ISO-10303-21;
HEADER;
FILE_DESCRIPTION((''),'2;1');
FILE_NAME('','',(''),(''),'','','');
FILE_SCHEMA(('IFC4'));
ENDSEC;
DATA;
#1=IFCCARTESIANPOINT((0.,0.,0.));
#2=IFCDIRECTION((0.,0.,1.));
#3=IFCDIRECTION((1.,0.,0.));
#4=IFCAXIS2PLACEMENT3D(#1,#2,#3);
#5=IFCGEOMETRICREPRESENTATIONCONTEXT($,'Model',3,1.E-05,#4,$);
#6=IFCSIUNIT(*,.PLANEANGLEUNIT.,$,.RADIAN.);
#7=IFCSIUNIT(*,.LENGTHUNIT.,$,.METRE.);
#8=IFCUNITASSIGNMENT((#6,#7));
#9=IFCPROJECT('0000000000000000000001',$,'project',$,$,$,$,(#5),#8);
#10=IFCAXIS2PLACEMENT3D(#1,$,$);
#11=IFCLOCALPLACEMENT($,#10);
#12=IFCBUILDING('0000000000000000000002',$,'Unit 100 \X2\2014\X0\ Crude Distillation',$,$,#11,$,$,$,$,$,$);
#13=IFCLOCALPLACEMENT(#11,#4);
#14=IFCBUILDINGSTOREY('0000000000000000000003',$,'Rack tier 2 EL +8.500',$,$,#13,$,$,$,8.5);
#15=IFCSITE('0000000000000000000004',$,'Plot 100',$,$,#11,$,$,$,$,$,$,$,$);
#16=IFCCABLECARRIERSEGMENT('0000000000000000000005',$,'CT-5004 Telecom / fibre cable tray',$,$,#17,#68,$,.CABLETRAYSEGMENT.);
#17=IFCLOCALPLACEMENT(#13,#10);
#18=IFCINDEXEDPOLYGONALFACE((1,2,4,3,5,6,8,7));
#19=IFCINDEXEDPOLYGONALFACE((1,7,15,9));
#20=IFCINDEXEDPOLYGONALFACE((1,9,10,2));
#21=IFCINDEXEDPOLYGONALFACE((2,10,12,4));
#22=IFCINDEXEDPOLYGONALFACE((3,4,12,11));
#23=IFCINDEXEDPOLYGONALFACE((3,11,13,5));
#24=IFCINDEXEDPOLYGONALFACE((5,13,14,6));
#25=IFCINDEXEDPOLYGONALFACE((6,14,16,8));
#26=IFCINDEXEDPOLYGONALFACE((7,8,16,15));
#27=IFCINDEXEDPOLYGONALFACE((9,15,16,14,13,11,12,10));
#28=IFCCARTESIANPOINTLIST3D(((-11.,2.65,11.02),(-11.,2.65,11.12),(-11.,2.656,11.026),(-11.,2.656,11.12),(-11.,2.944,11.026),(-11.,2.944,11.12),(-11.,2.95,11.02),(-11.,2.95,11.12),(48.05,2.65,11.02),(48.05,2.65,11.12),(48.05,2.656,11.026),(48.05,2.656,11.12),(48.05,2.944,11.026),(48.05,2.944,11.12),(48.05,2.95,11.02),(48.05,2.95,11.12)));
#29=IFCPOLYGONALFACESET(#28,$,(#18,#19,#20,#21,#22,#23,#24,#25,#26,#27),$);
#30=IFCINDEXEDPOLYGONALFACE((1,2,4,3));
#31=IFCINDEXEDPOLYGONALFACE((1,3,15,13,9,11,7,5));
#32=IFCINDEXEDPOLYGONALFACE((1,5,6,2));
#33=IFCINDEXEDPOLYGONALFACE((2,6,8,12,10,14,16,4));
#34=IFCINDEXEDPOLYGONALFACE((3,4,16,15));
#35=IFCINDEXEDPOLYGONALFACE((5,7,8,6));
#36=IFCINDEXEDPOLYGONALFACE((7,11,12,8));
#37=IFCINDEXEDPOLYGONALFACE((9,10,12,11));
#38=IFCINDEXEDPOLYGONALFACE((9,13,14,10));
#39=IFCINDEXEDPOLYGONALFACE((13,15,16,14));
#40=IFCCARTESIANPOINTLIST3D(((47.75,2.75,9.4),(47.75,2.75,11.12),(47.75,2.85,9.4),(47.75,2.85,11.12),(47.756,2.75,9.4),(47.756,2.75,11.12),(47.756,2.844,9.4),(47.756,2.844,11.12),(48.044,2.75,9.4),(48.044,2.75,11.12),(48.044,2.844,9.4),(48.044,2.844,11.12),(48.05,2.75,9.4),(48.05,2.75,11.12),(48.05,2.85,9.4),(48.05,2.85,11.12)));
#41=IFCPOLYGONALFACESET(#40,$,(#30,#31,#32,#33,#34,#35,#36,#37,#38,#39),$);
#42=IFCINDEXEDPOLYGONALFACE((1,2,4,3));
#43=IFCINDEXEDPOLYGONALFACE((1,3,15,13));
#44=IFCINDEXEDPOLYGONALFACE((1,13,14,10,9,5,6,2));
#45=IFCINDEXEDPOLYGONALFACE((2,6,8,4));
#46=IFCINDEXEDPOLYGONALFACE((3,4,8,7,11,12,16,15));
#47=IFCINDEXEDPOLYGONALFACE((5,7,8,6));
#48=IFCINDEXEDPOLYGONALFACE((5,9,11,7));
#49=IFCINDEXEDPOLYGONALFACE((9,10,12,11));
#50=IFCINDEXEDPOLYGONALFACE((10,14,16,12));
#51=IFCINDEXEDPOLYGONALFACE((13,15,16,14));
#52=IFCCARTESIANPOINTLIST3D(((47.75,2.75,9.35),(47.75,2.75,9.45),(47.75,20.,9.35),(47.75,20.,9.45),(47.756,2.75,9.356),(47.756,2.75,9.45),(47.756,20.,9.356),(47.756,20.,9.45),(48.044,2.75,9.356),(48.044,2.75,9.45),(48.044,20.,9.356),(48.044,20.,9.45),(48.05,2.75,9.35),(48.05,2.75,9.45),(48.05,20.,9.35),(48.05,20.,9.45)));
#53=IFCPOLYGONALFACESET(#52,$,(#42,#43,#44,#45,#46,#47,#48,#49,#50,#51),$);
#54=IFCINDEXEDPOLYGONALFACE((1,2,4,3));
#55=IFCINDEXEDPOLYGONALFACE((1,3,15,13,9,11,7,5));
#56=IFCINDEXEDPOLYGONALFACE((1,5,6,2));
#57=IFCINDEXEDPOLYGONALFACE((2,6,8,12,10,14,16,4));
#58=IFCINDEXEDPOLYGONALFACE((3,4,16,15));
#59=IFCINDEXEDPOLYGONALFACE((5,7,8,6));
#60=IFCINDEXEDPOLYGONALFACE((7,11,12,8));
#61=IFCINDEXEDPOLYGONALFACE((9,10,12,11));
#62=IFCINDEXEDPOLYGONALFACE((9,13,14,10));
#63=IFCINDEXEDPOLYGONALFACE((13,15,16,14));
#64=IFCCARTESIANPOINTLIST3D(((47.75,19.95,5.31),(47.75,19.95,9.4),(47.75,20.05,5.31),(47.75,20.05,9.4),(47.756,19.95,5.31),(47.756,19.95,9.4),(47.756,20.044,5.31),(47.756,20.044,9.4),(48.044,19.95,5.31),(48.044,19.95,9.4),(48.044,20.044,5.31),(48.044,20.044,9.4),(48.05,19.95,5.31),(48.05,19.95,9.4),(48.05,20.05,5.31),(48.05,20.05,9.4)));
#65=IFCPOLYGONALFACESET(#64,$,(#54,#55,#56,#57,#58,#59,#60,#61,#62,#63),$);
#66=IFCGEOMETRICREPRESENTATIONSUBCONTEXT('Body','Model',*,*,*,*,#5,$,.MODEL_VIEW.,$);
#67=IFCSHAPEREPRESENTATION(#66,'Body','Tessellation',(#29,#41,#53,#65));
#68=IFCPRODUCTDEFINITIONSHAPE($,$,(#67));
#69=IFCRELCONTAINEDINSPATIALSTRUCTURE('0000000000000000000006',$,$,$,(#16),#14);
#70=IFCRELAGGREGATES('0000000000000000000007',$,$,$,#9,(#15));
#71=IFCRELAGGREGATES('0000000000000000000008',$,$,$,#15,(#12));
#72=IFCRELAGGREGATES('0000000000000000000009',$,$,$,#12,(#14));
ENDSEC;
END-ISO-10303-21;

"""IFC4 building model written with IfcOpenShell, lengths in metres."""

from ifc_helpers import new_model, si_unit, frame, frame_2d, origin, origin_with_axes, place, context, subcontext, project, spatial, u_section, extrude, element, save


model = new_model("IFC4")

# Units and contexts
model_context = context("Model", 3, precision=1e-05, world=origin_with_axes())
body_context = subcontext(model_context, "Body", "Model", "MODEL_VIEW")
ifc_project = project(units=[si_unit("PLANEANGLEUNIT", "RADIAN"), si_unit("LENGTHUNIT", "METRE")], contexts=[model_context])

# Site, building, storey
placement = place(None, origin())
site = spatial("IfcSite", under=ifc_project, at=placement, Name="Plot 100")
building = spatial("IfcBuilding", under=site, at=placement, Name="Unit 100 — Crude Distillation")
storey_placement = place(placement, origin_with_axes())
storey = spatial("IfcBuildingStorey", under=building, at=storey_placement, Name="Rack tier 2 EL +8.500", Elevation=8.5)

# Cable carrier segment
cable_carrier_segment_placement = place(storey_placement, origin_with_axes())
element("IfcCableCarrierSegment", 1, at=cable_carrier_segment_placement, inside=storey, Name="CT-5004 Telecom / fibre cable tray", PredefinedType="CABLETRAYSEGMENT", context=body_context, shape_type="SweptSolid", body=[
    extrude(u_section(Depth=0.3, FlangeWidth=0.1, WebThickness=0.006, FlangeThickness=0.006, at=frame_2d((0.0, 0.0), x_axis=(0.0, 1.0))), frame((-11.0, 2.8, 11.07), z_axis=(1.0, 0.0, 0.0), x_axis=(0.0, 1.0, 0.0)), (0.0, 0.0, 1.0), 59.05),
    extrude(u_section(Depth=0.3, FlangeWidth=0.1, WebThickness=0.006, FlangeThickness=0.006, at=frame_2d((0.0, 0.0), x_axis=(0.0, 1.0))), frame((47.9, 2.8, 11.12), z_axis=(0.0, 0.0, -1.0), x_axis=(1.0, 0.0, 0.0)), (0.0, 0.0, 1.0), 1.72),
    extrude(u_section(Depth=0.3, FlangeWidth=0.1, WebThickness=0.006, FlangeThickness=0.006, at=frame_2d((0.0, 0.0), x_axis=(0.0, 1.0))), frame((47.9, 2.75, 9.4), z_axis=(0.0, 1.0, 0.0), x_axis=(-1.0, 0.0, 0.0)), (0.0, 0.0, 1.0), 17.25),
    extrude(u_section(Depth=0.3, FlangeWidth=0.1, WebThickness=0.006, FlangeThickness=0.006, at=frame_2d((0.0, 0.0), x_axis=(0.0, 1.0))), frame((47.9, 20.0, 9.4), z_axis=(0.0, 0.0, -1.0), x_axis=(1.0, 0.0, 0.0)), (0.0, 0.0, 1.0), 4.09),
])

save(model, "model.ifc")
